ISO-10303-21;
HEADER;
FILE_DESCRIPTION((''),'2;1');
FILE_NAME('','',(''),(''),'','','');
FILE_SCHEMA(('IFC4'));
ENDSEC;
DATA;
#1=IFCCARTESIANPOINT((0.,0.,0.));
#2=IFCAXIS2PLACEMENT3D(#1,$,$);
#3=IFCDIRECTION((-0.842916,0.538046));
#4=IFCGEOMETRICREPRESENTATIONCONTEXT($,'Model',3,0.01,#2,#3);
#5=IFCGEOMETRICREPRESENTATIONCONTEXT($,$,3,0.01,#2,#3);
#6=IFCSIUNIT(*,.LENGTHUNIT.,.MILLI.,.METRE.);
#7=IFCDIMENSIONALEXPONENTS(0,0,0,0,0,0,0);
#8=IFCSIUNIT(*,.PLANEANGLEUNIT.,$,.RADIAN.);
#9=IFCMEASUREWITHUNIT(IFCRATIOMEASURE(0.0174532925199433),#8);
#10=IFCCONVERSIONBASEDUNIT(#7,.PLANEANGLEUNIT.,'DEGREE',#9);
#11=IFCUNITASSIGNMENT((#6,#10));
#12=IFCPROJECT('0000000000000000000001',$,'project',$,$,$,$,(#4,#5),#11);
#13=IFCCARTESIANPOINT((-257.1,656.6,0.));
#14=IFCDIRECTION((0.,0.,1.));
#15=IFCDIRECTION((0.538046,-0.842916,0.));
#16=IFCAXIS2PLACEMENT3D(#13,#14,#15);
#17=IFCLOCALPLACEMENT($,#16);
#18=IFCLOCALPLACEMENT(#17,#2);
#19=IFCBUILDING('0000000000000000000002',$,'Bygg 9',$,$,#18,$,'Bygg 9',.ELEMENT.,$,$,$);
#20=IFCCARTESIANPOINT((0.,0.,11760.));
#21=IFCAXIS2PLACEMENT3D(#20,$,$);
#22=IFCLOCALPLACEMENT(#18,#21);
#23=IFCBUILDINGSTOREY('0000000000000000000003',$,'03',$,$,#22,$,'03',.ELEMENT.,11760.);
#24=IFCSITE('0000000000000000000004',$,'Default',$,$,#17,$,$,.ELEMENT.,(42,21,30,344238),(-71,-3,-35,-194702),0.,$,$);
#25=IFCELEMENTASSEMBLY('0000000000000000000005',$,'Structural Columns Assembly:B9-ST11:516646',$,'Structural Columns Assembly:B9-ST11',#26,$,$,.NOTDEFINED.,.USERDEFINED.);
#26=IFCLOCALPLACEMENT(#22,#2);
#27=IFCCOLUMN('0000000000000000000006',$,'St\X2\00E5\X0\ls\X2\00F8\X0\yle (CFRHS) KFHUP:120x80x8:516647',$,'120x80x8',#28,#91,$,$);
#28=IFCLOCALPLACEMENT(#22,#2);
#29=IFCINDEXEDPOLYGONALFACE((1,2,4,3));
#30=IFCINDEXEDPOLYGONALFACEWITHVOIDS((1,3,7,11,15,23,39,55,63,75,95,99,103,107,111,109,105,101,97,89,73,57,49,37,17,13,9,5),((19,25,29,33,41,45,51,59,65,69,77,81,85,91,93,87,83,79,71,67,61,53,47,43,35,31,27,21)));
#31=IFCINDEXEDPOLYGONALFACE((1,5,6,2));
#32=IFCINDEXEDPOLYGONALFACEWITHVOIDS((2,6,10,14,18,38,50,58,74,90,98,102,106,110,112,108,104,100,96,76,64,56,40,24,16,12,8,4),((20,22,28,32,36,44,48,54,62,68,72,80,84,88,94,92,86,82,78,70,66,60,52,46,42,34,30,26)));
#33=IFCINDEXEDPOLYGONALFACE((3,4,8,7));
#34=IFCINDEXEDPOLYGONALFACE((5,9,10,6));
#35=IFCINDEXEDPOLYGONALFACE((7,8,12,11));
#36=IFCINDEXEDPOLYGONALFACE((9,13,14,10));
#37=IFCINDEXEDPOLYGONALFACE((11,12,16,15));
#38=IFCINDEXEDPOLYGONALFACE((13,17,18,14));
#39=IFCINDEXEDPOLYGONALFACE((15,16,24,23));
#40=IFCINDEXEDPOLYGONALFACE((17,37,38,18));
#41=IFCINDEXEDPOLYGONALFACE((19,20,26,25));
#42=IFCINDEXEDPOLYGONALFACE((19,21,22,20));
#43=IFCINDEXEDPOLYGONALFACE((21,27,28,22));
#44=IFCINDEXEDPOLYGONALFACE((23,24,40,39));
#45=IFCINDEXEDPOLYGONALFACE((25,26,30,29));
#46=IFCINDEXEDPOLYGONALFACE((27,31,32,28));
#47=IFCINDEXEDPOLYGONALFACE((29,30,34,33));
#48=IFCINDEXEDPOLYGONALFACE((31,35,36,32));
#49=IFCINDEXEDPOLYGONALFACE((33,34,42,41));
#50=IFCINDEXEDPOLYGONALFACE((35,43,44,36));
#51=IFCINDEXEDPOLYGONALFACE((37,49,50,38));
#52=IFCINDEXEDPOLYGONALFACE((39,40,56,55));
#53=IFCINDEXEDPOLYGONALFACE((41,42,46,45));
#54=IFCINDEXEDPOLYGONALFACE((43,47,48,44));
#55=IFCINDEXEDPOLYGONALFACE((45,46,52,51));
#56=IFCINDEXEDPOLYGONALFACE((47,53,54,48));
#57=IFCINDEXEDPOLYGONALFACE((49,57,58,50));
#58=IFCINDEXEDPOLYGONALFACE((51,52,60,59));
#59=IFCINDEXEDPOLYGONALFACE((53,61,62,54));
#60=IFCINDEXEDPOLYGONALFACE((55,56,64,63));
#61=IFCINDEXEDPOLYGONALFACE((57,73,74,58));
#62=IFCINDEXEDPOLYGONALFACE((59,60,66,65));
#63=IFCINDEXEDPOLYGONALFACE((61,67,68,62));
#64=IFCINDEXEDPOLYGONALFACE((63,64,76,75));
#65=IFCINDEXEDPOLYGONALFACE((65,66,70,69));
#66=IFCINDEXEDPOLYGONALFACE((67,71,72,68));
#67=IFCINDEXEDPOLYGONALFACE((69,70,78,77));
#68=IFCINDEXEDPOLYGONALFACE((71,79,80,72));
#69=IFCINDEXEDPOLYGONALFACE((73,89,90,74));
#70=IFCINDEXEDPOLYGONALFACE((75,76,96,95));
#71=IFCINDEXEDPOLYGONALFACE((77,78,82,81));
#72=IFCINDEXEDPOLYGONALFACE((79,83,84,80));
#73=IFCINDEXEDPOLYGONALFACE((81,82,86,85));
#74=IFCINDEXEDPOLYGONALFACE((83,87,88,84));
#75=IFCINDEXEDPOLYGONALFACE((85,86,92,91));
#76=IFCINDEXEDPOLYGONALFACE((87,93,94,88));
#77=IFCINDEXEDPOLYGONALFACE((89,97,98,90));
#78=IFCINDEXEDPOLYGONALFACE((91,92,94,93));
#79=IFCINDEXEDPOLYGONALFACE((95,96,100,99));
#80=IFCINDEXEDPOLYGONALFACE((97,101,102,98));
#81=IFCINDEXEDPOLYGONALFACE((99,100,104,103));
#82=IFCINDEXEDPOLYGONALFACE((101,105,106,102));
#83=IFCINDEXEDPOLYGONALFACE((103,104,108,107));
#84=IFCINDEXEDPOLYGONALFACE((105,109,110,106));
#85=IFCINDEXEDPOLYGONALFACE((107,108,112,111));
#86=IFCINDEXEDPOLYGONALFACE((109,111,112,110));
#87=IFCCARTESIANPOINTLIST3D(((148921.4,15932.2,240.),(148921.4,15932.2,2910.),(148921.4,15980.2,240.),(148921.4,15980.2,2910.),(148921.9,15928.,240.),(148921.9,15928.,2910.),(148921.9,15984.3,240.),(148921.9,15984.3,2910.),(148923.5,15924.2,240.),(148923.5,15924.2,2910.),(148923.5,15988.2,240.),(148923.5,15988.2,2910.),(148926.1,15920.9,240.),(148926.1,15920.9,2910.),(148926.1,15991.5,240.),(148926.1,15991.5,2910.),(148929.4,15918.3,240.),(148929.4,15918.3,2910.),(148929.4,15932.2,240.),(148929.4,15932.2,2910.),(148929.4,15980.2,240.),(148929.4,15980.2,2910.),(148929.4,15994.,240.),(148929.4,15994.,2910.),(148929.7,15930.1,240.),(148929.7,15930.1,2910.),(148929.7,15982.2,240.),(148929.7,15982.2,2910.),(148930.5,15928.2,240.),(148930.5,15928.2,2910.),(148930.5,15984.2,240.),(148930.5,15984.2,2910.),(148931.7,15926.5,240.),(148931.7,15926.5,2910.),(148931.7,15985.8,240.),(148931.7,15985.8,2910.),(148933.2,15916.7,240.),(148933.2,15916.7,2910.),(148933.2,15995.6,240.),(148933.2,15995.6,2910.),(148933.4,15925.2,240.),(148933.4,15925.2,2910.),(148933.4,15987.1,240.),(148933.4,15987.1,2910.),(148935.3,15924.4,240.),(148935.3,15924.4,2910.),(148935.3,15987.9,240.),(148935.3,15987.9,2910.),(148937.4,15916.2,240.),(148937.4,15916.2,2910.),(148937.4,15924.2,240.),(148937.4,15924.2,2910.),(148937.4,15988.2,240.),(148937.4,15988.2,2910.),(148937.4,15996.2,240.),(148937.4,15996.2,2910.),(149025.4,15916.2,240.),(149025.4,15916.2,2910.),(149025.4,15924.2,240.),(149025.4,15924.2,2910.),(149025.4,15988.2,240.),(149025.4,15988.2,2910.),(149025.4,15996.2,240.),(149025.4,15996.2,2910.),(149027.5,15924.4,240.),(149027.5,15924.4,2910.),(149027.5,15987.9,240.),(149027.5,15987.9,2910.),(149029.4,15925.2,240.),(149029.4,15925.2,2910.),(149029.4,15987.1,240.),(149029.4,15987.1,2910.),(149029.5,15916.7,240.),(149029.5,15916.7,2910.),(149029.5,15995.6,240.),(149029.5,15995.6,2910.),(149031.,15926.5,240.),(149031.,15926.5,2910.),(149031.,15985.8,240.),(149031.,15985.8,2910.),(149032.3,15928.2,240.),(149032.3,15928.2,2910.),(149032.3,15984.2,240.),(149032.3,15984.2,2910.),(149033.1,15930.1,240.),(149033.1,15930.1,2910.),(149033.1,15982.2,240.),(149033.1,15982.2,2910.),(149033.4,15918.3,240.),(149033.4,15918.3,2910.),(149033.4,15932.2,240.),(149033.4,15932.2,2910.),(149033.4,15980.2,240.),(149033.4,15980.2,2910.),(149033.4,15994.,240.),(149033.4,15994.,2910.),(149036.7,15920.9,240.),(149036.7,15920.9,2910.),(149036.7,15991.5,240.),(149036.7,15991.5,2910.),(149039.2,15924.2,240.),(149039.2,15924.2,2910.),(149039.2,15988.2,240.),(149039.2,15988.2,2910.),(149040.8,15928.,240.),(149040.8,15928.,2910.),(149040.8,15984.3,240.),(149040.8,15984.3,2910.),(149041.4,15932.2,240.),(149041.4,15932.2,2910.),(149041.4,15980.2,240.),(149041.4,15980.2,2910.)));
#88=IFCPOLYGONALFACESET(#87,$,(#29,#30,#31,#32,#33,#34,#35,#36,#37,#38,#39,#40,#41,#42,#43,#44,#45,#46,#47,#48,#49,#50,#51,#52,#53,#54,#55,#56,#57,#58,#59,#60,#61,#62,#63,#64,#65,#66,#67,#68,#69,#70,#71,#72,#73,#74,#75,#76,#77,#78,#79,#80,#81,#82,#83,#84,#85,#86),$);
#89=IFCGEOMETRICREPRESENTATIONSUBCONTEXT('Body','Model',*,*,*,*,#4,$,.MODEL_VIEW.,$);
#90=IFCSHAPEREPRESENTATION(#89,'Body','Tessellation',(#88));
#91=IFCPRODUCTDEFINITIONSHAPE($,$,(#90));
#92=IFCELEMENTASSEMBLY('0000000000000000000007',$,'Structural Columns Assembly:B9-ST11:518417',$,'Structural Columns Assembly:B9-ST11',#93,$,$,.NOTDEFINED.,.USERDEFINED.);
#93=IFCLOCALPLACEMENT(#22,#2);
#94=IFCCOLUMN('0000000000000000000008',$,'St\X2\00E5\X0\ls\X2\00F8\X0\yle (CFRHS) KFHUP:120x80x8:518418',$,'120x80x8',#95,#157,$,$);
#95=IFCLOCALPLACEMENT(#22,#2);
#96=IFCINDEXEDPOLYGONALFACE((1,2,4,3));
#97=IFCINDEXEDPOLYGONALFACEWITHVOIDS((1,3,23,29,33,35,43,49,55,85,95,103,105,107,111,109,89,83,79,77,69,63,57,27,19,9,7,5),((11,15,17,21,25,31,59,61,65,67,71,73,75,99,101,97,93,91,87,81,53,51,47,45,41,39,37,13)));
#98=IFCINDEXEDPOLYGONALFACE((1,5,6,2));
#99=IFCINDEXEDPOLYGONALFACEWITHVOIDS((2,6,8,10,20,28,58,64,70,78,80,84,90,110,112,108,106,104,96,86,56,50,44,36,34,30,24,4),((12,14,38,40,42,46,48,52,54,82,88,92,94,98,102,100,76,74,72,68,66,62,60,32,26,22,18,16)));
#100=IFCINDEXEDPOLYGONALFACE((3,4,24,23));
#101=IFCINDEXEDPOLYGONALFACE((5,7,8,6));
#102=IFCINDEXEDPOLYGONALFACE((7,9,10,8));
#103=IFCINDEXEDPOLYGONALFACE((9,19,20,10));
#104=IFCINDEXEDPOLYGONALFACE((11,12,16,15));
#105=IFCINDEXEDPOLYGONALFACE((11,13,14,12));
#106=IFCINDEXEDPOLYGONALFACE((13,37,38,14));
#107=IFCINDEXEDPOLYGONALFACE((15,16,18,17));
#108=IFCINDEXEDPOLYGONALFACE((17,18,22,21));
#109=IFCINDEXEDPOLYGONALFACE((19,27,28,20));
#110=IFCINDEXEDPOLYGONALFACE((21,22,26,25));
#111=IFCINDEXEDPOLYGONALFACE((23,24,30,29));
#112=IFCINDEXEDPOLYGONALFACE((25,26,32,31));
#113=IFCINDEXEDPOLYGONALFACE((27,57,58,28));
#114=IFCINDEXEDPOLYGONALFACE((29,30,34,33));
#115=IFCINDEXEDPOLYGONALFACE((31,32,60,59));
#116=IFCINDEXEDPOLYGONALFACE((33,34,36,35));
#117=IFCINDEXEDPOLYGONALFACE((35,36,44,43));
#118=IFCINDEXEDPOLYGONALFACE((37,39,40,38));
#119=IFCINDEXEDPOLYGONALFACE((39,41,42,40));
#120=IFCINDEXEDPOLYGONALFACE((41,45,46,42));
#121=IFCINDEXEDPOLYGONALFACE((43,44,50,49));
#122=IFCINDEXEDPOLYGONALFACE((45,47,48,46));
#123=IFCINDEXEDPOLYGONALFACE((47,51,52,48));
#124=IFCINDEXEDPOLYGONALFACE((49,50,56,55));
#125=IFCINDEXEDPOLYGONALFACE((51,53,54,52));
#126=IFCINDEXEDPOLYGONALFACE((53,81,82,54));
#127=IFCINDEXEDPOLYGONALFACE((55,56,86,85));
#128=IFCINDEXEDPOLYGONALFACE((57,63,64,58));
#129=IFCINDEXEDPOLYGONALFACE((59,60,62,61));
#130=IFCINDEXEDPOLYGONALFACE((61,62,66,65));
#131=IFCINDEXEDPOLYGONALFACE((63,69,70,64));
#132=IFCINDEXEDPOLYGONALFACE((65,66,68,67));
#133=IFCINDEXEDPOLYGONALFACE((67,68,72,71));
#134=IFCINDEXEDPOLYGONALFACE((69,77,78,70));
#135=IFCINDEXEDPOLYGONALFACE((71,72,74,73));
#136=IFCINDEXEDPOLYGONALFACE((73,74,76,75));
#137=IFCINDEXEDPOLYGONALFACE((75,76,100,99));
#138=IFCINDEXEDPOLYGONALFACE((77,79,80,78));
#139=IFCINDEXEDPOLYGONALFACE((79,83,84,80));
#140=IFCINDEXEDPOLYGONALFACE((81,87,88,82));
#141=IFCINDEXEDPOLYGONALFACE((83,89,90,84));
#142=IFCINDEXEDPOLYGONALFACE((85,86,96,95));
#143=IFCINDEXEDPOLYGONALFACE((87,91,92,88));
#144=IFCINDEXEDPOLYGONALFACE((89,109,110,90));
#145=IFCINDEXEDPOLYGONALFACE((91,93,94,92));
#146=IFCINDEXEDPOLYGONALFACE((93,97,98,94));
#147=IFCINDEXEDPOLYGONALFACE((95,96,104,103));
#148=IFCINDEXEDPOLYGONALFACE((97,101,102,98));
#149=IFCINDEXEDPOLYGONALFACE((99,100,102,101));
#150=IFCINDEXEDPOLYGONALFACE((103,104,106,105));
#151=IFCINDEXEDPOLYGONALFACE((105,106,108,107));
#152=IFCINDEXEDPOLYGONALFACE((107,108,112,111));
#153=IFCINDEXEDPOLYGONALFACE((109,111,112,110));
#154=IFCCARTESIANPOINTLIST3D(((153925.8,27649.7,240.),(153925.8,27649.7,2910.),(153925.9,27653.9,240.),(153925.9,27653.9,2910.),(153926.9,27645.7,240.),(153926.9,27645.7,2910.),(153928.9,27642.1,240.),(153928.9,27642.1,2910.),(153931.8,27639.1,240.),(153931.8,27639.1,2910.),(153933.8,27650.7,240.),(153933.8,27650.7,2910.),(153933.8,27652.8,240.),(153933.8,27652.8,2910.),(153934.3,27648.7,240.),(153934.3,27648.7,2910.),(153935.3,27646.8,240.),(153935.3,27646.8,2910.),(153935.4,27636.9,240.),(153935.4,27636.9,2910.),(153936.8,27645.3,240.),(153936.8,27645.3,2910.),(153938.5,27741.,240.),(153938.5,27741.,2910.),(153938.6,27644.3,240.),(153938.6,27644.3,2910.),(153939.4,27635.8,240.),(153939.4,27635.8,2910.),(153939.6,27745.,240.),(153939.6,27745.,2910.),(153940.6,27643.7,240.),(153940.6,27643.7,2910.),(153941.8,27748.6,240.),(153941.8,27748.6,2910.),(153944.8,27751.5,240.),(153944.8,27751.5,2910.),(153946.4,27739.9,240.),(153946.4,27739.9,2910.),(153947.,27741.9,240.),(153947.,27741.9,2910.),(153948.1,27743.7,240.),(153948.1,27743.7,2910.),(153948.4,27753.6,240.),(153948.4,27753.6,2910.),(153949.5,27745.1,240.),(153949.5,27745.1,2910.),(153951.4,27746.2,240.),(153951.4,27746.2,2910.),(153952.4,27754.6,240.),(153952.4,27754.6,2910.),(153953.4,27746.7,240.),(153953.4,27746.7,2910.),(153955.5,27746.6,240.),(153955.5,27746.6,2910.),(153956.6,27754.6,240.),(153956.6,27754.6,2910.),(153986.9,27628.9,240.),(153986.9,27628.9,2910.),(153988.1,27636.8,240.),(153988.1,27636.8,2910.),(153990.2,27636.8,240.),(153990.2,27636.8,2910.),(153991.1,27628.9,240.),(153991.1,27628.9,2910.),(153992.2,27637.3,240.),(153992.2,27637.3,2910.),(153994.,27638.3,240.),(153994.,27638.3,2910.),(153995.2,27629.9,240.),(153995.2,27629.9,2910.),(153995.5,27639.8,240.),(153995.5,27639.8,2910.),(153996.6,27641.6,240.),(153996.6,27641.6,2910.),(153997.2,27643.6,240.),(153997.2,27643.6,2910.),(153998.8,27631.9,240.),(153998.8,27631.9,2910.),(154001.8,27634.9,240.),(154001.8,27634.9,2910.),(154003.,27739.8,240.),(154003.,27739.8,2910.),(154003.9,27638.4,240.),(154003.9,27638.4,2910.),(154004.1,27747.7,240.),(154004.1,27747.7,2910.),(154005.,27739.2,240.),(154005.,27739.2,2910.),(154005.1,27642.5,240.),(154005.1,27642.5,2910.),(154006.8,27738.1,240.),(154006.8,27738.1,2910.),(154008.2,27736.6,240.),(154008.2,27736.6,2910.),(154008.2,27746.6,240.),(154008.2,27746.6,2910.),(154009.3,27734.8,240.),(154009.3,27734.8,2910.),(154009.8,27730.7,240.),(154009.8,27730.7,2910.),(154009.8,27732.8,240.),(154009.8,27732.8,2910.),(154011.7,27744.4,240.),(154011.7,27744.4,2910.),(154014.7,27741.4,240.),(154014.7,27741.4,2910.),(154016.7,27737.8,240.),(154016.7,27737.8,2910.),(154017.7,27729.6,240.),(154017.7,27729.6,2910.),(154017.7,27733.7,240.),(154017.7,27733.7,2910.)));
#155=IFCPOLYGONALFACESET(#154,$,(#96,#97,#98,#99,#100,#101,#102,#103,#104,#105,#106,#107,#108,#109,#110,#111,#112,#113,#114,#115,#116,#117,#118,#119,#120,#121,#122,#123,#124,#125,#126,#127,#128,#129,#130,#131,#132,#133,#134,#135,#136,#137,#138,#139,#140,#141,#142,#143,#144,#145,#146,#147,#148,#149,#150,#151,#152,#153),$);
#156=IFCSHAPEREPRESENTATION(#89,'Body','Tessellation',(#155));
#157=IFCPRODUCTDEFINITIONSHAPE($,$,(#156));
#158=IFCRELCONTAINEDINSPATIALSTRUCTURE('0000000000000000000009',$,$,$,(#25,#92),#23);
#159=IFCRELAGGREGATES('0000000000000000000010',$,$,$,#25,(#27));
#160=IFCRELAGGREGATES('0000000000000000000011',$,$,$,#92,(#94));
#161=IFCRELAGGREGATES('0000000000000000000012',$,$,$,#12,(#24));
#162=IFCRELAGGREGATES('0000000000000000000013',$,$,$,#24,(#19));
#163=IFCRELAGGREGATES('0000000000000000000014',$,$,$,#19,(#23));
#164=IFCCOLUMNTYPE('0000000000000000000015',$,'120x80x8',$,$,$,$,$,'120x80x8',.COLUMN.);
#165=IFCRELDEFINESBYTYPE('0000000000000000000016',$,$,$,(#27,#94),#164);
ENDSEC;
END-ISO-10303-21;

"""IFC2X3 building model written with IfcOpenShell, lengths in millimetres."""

from ifc_helpers import new_model, entity, si_unit, converted_unit, direction, frame, frame_2d, origin, place, context, subcontext, project, spatial, polyline, circle_curve, parameter, trimmed, segment, composite_curve, outline, extrude, source, transform, mapped, type_object, type_shapes, element, aggregate, save


model = new_model("IFC2X3")

# Units and contexts
model_context = context("Model", 3, precision=0.01, world=origin(), true_north=direction((-0.842916, 0.538046)))
context_of_model = context(None, 3, precision=0.01, world=origin(), true_north=direction((-0.842916, 0.538046)))
body_context = subcontext(model_context, "Body", "Model", "MODEL_VIEW")
ifc_project = project(units=[si_unit("LENGTHUNIT", "METRE", prefix="MILLI"), converted_unit("PLANEANGLEUNIT", "DEGREE", entity("IfcRatioMeasure", 0.0174532925199433), si_unit("PLANEANGLEUNIT", "RADIAN"), dimensions=[0, 0, 0, 0, 0, 0, 0])], contexts=[model_context, context_of_model])

# Site, building, storey
site_placement = place(None, frame((-257.1, 656.6, 0.0), z_axis=(0.0, 0.0, 1.0), x_axis=(0.538046, -0.842916, 0.0)))
site = spatial("IfcSite", under=ifc_project, at=site_placement, Name="Default", CompositionType="ELEMENT", RefLatitude=(42, 21, 30, 344238), RefLongitude=(-71, -3, -35, -194702), RefElevation=0.0)
building_placement = place(site_placement, origin())
building = spatial("IfcBuilding", under=site, at=building_placement, Name="Bygg 9", LongName="Bygg 9", CompositionType="ELEMENT")
storey_placement = place(building_placement, frame((0.0, 0.0, 11760.0)))
storey = spatial("IfcBuildingStorey", under=building, at=storey_placement, Name="03", LongName="03", CompositionType="ELEMENT", Elevation=11760.0)

# Element assemblies, columns
assembly_1_placement = place(storey_placement, origin())
assembly_1 = element("IfcElementAssembly", 1, at=assembly_1_placement, inside=storey, Name="Structural Columns Assembly:B9-ST11:516646", ObjectType="Structural Columns Assembly:B9-ST11", AssemblyPlace="NOTDEFINED", PredefinedType="USERDEFINED")
column_type_1 = type_object("IfcColumnType", Name="120x80x8", ElementType="120x80x8", PredefinedType="COLUMN")
shared_shape_1 = source(origin(), body_context, "Body", "SweptSolid", [
    extrude(outline(composite_curve([segment(trimmed(circle_curve(frame_2d((-24.0, 44.0), x_axis=(1.0, 0.0)), 16.0), [parameter(90.0)], [parameter(180.0)], True, "PARAMETER"), True, "CONTINUOUS"), segment(polyline([(-40.0, 44.0), (-40.0, -44.0)]), True, "CONTINUOUS"), segment(trimmed(circle_curve(frame_2d((-24.0, -44.0), x_axis=(1.0, 0.0)), 16.0), [parameter(180.0)], [parameter(270.0)], True, "PARAMETER"), True, "CONTINUOUS"), segment(polyline([(-24.0, -60.0), (24.0, -60.0)]), True, "CONTINUOUS"), segment(trimmed(circle_curve(frame_2d((24.0, -44.0), x_axis=(1.0, 0.0)), 16.0), [parameter(270.0)], [parameter(0.0)], True, "PARAMETER"), True, "CONTINUOUS"), segment(polyline([(40.0, -44.0), (40.0, 44.0)]), True, "CONTINUOUS"), segment(trimmed(circle_curve(frame_2d((24.0, 44.0), x_axis=(1.0, 0.0)), 16.0), [parameter(0.0)], [parameter(90.0)], True, "PARAMETER"), True, "CONTINUOUS"), segment(polyline([(24.0, 60.0), (-24.0, 60.0)]), True, "CONTINUOUS")], self_intersect=False), holes=[composite_curve([segment(polyline([(-24.0, 52.0), (24.0, 52.0)]), True, "CONTINUOUS"), segment(trimmed(circle_curve(frame_2d((24.0, 44.0), x_axis=(1.0, 0.0)), 8.0), [parameter(360.0)], [parameter(90.0)], True, "PARAMETER"), False, "CONTINUOUS"), segment(polyline([(32.0, 44.0), (32.0, -44.0)]), True, "CONTINUOUS"), segment(trimmed(circle_curve(frame_2d((24.0, -44.0), x_axis=(1.0, 0.0)), 8.0), [parameter(270.0)], [parameter(360.0)], True, "PARAMETER"), False, "CONTINUOUS"), segment(polyline([(24.0, -52.0), (-24.0, -52.0)]), True, "CONTINUOUS"), segment(trimmed(circle_curve(frame_2d((-24.0, -44.0), x_axis=(1.0, 0.0)), 8.0), [parameter(180.0)], [parameter(270.0)], True, "PARAMETER"), False, "CONTINUOUS"), segment(polyline([(-32.0, -44.0), (-32.0, 44.0)]), True, "CONTINUOUS"), segment(trimmed(circle_curve(frame_2d((-24.0, 44.0), x_axis=(1.0, 0.0)), 8.0), [parameter(90.0)], [parameter(180.0)], True, "PARAMETER"), False, "CONTINUOUS")], self_intersect=False)]), frame((41.6, 61.6, 0.0), z_axis=(0.0, 0.0, 1.0), x_axis=(-1.0, 0.0, 0.0)), (0.0, 0.0, 1.0), 2670.0),
])
type_shapes(column_type_1, [shared_shape_1])
column_1_placement = place(assembly_1_placement, frame((149043.0, 15914.6, 240.0), z_axis=(0.0, 0.0, 1.0), x_axis=(0.0, 1.0, 0.0)))
column_1 = element("IfcColumn", 2, at=column_1_placement, type_object=column_type_1, Name="Stålsøyle (CFRHS) KFHUP:120x80x8:516647", ObjectType="120x80x8", context=body_context, shape_type="MappedRepresentation", body=[
    mapped(shared_shape_1, transform((0.0, 0.0, 0.0), scale=1.0)),
])
assembly_2_placement = place(storey_placement, origin())
assembly_2 = element("IfcElementAssembly", 3, at=assembly_2_placement, inside=storey, Name="Structural Columns Assembly:B9-ST11:518417", ObjectType="Structural Columns Assembly:B9-ST11", AssemblyPlace="NOTDEFINED", PredefinedType="USERDEFINED")
column_2_placement = place(assembly_2_placement, frame((154021.8, 27746.7, 240.0), z_axis=(0.0, 0.0, 1.0), x_axis=(-0.989691, 0.143216, 0.0)))
column_2 = element("IfcColumn", 4, at=column_2_placement, type_object=column_type_1, Name="Stålsøyle (CFRHS) KFHUP:120x80x8:518418", ObjectType="120x80x8", context=body_context, shape_type="MappedRepresentation", body=[
    mapped(shared_shape_1, transform((0.0, 0.0, 0.0), scale=1.0)),
])

aggregate(assembly_1, [column_1])
aggregate(assembly_2, [column_2])

save(model, "model.ifc")
